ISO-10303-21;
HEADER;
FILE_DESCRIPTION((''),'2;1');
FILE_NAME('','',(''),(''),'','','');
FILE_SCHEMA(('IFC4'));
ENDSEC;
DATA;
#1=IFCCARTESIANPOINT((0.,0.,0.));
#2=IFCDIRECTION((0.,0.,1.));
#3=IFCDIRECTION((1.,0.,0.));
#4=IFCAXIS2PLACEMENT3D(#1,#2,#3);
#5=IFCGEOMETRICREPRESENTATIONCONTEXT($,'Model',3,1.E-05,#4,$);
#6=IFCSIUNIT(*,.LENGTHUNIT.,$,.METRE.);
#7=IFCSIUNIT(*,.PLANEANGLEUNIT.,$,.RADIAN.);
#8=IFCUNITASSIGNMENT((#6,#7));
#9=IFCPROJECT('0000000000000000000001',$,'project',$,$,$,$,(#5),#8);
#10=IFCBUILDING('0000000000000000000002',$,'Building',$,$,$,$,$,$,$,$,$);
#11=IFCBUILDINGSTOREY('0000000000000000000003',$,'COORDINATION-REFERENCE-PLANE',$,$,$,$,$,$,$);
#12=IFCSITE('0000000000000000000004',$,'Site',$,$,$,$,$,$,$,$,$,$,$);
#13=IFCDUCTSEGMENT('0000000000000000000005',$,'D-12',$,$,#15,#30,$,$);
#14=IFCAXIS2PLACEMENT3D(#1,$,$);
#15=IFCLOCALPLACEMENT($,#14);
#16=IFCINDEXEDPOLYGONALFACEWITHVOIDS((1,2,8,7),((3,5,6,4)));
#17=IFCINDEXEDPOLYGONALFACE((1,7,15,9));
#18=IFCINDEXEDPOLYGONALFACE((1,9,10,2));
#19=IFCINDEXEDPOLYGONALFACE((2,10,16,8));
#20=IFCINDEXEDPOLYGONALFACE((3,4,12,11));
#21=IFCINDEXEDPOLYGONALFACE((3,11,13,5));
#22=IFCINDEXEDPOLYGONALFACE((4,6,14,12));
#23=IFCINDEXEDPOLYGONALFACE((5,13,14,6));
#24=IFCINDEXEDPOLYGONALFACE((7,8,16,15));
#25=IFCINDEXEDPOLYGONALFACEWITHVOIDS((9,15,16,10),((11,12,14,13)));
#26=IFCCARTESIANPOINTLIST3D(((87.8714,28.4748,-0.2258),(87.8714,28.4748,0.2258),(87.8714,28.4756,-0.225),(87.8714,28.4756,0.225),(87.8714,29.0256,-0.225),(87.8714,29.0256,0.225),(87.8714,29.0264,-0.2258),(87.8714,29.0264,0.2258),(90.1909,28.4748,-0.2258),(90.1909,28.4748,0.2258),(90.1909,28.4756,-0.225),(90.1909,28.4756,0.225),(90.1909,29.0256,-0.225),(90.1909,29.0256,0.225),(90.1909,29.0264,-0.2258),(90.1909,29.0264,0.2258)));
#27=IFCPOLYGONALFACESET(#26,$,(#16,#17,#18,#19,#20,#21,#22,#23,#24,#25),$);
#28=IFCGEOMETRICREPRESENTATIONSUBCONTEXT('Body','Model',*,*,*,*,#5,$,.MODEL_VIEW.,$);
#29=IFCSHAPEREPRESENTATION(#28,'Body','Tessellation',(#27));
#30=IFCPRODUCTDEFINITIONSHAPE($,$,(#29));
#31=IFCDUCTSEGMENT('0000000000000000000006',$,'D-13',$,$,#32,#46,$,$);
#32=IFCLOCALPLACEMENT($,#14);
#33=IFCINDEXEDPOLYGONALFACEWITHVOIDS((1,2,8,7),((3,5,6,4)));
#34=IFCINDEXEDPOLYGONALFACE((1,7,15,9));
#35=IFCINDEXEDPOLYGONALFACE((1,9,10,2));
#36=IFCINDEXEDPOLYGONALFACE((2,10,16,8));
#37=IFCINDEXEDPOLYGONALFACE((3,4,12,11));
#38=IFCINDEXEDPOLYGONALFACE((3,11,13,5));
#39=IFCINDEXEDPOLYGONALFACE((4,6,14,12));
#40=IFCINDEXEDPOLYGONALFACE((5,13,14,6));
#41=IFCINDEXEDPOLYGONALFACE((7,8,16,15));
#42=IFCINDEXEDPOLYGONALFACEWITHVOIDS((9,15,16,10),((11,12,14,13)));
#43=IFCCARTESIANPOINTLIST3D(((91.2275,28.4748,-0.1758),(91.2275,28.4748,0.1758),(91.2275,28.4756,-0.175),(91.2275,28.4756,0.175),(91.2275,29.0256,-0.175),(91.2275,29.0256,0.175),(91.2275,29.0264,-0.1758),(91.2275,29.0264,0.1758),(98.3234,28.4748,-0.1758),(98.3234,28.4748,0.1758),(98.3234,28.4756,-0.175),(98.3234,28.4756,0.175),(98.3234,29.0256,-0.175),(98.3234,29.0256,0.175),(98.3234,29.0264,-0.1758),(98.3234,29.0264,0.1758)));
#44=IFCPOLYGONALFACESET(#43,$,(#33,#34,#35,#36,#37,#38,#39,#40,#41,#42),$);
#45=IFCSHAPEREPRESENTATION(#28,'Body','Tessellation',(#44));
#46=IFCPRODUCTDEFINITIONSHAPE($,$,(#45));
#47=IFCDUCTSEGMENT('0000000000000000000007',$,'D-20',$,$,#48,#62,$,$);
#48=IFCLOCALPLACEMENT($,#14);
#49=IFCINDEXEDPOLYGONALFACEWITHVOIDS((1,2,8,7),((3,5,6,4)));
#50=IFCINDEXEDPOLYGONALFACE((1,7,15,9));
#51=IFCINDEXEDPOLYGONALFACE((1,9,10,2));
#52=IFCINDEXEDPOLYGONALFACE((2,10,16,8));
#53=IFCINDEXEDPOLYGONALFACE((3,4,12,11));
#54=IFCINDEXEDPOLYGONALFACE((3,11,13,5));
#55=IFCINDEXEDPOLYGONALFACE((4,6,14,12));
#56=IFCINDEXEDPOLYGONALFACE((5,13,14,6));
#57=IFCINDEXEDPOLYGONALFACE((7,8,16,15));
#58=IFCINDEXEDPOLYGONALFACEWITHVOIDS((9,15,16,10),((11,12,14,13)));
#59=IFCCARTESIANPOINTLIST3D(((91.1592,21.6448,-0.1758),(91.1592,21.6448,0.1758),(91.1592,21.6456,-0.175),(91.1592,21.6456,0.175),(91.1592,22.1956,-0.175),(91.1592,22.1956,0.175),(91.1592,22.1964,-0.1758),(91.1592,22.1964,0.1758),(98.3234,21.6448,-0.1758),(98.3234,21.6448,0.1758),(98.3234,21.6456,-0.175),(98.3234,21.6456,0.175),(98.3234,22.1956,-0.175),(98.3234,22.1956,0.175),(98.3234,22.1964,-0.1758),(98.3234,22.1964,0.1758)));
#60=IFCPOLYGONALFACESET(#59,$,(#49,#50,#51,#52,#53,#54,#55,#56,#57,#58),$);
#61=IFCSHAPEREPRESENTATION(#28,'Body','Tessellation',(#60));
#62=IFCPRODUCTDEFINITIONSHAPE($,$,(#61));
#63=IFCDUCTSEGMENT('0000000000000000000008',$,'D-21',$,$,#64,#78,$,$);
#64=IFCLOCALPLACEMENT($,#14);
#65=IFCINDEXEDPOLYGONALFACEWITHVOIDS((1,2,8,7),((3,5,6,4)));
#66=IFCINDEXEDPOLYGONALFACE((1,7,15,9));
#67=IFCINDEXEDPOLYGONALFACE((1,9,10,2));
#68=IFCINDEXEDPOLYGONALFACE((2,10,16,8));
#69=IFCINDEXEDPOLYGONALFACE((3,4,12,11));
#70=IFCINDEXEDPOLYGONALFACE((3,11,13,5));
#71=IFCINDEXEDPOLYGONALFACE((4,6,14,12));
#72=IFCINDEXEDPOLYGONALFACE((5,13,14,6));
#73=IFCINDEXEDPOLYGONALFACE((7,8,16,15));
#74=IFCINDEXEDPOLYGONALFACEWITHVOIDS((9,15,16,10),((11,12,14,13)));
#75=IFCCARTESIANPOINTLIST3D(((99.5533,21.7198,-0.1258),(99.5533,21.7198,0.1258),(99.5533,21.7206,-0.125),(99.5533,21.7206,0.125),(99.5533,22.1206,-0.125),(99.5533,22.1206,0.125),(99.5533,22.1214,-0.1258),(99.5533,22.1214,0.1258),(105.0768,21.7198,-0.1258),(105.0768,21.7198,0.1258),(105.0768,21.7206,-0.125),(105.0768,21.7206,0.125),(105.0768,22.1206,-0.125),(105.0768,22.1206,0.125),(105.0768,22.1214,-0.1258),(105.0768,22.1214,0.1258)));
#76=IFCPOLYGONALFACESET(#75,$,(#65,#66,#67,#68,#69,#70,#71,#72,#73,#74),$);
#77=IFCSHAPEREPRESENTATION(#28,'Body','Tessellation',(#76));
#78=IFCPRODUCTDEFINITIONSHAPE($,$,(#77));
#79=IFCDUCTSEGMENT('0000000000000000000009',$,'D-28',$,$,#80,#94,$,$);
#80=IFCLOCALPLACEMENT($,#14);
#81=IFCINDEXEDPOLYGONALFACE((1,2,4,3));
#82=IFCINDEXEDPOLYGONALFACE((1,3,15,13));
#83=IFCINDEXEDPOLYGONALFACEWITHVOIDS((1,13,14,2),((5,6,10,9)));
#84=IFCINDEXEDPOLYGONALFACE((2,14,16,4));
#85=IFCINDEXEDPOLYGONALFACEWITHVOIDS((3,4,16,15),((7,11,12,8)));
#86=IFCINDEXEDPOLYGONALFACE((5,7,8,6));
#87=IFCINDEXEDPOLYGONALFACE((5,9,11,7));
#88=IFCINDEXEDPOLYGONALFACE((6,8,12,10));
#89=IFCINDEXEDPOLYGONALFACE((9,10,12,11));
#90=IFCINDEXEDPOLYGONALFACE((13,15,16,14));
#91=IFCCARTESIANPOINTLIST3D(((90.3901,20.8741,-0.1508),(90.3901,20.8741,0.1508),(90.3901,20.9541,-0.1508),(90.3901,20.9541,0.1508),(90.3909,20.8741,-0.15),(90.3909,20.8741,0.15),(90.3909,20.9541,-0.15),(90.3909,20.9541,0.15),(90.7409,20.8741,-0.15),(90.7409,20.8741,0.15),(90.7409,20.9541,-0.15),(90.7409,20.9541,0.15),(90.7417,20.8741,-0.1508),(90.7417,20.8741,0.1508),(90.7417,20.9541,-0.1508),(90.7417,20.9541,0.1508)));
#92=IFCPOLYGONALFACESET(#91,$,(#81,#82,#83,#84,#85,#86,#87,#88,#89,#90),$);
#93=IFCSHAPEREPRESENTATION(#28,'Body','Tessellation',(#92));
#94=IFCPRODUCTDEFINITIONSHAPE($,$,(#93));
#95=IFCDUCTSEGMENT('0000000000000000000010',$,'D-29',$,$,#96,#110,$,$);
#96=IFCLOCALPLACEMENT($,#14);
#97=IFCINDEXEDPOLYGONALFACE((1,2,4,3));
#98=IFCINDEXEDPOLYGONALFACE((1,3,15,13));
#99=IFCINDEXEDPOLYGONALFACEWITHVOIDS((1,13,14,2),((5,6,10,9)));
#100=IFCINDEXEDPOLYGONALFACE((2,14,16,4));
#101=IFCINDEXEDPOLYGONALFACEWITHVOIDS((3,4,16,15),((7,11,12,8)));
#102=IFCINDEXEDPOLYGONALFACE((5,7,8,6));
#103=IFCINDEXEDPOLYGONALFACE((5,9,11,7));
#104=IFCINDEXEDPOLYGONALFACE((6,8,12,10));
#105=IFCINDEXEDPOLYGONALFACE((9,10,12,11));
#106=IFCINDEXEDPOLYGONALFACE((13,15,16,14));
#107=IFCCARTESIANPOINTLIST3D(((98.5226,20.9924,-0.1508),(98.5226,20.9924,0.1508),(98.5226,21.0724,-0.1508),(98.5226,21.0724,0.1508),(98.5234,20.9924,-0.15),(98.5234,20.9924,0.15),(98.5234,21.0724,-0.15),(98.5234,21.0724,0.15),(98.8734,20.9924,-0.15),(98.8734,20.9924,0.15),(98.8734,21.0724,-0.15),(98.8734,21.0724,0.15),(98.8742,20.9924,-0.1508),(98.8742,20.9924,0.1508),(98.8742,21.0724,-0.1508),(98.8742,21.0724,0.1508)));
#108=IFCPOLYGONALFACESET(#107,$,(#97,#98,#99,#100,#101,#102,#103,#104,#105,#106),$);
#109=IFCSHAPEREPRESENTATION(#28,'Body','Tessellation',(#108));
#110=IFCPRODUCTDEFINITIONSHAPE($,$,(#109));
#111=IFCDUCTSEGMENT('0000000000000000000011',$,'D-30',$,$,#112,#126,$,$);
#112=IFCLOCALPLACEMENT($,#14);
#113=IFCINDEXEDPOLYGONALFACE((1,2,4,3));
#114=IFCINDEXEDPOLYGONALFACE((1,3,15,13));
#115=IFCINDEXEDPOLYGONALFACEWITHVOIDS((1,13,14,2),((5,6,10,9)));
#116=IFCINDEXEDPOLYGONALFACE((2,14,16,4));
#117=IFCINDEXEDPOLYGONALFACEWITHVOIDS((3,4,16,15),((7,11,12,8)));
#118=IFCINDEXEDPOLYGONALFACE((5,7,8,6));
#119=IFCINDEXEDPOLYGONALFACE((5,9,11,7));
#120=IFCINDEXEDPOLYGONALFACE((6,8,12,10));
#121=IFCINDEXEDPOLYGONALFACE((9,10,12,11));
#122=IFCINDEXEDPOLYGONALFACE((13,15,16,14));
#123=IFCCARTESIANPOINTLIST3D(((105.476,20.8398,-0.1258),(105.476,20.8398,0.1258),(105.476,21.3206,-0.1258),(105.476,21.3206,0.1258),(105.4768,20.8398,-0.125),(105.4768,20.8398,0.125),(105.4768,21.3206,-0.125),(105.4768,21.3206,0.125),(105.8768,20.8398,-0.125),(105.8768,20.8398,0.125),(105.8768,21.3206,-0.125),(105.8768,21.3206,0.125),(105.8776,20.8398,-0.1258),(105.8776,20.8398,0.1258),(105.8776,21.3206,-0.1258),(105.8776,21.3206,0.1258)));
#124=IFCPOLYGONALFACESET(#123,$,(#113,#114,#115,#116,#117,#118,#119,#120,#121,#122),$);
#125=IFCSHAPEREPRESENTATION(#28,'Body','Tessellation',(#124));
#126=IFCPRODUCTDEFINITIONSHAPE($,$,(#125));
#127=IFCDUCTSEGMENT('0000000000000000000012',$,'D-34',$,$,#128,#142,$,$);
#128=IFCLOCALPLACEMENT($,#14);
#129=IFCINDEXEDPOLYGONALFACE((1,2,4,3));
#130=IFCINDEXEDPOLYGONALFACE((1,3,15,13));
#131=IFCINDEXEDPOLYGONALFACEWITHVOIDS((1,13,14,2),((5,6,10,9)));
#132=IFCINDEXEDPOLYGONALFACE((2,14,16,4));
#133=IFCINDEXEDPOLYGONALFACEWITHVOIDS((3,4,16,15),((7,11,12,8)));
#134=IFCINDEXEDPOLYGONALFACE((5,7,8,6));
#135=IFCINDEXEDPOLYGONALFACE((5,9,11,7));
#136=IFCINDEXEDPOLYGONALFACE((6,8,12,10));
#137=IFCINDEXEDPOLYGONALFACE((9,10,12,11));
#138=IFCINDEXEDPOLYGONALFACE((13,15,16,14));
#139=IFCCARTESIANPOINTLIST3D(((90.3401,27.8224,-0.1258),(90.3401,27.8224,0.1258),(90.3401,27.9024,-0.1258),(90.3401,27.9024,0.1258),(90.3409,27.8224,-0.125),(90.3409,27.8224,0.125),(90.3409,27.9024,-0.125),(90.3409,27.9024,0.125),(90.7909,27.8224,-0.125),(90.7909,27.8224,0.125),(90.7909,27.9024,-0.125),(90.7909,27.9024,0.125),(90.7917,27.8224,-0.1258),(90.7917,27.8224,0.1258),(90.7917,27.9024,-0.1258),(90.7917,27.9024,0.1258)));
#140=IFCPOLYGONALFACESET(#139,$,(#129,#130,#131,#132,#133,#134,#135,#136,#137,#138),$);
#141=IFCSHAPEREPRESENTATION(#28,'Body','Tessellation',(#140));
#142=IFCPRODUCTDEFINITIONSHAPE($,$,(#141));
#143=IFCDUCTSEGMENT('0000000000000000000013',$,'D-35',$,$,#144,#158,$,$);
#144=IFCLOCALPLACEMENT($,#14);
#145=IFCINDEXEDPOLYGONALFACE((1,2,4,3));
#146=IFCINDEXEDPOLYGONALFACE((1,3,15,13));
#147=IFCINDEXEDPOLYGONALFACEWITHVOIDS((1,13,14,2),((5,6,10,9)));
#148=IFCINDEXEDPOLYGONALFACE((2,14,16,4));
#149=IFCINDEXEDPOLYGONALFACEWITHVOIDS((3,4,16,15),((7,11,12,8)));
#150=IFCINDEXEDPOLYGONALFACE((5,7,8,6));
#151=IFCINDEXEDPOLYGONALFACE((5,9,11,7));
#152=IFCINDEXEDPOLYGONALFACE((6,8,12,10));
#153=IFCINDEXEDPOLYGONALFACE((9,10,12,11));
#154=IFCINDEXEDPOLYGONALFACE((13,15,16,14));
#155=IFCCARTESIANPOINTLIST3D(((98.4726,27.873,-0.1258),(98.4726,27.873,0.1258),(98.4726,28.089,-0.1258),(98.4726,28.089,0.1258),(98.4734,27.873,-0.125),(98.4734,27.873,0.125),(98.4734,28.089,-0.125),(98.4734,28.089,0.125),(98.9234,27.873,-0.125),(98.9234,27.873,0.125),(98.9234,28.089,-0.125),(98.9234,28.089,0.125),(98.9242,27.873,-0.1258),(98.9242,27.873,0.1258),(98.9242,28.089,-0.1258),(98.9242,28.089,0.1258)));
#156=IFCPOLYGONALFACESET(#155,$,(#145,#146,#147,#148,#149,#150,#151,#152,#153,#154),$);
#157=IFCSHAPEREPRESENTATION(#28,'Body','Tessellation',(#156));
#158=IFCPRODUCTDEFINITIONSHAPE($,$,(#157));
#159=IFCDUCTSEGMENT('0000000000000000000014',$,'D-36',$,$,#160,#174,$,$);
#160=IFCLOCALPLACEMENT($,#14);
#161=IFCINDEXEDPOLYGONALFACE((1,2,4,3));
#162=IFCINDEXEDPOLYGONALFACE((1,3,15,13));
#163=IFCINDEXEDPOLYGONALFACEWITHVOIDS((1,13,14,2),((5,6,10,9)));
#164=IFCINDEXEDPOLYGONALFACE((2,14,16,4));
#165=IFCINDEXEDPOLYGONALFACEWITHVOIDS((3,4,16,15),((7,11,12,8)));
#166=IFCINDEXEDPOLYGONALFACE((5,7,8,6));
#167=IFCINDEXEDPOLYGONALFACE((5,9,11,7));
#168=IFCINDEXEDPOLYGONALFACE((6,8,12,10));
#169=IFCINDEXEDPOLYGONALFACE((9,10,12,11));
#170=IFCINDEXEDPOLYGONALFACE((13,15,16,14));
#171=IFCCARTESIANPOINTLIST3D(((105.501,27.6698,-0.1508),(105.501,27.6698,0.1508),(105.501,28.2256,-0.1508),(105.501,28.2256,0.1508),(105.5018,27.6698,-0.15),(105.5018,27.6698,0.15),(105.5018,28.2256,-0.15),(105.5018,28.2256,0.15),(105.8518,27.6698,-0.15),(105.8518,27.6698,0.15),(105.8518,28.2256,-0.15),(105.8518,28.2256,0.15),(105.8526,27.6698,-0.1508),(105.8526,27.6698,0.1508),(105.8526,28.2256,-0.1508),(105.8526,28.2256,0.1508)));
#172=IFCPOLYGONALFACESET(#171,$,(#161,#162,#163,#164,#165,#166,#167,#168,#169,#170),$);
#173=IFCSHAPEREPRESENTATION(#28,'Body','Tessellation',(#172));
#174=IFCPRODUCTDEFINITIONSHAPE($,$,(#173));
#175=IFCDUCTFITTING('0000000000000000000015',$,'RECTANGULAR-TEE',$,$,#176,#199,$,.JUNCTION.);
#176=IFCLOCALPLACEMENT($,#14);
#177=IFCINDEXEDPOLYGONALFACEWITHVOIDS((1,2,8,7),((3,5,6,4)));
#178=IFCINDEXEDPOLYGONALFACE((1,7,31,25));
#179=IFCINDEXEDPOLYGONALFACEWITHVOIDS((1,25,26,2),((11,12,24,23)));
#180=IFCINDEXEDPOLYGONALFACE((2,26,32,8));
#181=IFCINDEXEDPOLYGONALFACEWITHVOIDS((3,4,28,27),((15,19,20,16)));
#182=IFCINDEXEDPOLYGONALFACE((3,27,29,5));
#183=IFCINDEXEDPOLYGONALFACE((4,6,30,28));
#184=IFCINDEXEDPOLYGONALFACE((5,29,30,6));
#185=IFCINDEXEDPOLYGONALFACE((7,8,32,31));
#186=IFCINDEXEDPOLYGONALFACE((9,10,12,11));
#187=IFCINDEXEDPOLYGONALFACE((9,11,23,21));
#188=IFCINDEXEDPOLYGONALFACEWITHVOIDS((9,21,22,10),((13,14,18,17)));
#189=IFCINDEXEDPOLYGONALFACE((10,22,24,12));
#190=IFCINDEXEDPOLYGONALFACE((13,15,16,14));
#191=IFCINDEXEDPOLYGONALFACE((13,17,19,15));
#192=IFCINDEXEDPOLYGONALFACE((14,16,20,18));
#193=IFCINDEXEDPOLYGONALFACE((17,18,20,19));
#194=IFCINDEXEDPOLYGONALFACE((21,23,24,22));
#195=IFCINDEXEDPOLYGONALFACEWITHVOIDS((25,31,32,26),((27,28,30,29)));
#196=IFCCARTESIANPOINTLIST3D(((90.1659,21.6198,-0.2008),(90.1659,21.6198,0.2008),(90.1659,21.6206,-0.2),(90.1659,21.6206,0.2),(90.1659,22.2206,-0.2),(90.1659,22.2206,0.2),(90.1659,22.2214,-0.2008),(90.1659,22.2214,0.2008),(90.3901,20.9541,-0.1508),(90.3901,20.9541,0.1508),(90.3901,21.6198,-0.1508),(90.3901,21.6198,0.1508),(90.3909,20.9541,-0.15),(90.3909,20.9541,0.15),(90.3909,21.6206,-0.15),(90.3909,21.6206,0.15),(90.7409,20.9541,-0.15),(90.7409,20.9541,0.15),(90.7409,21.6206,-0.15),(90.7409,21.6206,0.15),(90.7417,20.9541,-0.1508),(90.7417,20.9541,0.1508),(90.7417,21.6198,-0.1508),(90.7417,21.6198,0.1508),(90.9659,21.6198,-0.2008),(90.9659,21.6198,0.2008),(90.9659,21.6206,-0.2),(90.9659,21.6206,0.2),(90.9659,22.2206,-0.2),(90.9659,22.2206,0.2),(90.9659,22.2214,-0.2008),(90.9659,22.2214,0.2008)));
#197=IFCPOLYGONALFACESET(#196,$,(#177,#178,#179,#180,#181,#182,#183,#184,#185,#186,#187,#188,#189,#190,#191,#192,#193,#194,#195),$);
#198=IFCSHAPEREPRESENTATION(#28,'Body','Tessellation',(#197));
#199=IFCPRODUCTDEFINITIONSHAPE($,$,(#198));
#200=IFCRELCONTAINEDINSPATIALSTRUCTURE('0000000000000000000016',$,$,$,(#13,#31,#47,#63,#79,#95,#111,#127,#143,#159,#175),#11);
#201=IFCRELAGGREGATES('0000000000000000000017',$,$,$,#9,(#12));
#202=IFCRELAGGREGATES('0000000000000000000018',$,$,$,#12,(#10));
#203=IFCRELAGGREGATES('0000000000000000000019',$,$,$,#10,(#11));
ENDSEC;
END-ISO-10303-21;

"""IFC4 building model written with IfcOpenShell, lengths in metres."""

from ifc_helpers import new_model, si_unit, frame, origin, origin_with_axes, place, context, subcontext, project, spatial, rectangle, hollow_rectangle, extrude, boolean, element, save


model = new_model("IFC4")

# Units and contexts
model_context = context("Model", 3, precision=1e-05, world=origin_with_axes())
body_context_1 = subcontext(model_context, "Body", "Model", "MODEL_VIEW")
ifc_project = project(units=[si_unit("LENGTHUNIT", "METRE"), si_unit("PLANEANGLEUNIT", "RADIAN")], contexts=[model_context])

# Site, building, storey
site = spatial("IfcSite", under=ifc_project, Name="Site")
building = spatial("IfcBuilding", under=site, Name="Building")
storey = spatial("IfcBuildingStorey", under=building, Name="COORDINATION-REFERENCE-PLANE")

# Duct segments
duct_segment_1_placement = place(None, frame((87.8714, 28.7506, 0.0), z_axis=(1.0, 0.0, 0.0), x_axis=(0.0, 1.0, 0.0)))
element("IfcDuctSegment", 1, at=duct_segment_1_placement, inside=storey, Name="D-12", context=body_context_1, shape_type="SweptSolid", body=[
    extrude(hollow_rectangle(XDim=0.5516, YDim=0.4516, WallThickness=0.0008), origin(), (0.0, 0.0, 1.0), 2.3195),
])
duct_segment_2_placement = place(None, frame((91.2275, 28.7506, 0.0), z_axis=(1.0, 0.0, 0.0), x_axis=(0.0, 1.0, 0.0)))
element("IfcDuctSegment", 2, at=duct_segment_2_placement, inside=storey, Name="D-13", context=body_context_1, shape_type="SweptSolid", body=[
    extrude(hollow_rectangle(XDim=0.5516, YDim=0.3516, WallThickness=0.0008), origin(), (0.0, 0.0, 1.0), 7.0959),
])
duct_segment_3_placement = place(None, frame((91.1592, 21.9206, 0.0), z_axis=(1.0, 0.0, 0.0), x_axis=(0.0, 1.0, 0.0)))
element("IfcDuctSegment", 3, at=duct_segment_3_placement, inside=storey, Name="D-20", context=body_context_1, shape_type="SweptSolid", body=[
    extrude(hollow_rectangle(XDim=0.5516, YDim=0.3516, WallThickness=0.0008), origin(), (0.0, 0.0, 1.0), 7.1642),
])
duct_segment_4_placement = place(None, frame((99.5533, 21.9206, 0.0), z_axis=(1.0, 0.0, 0.0), x_axis=(0.0, 1.0, 0.0)))
element("IfcDuctSegment", 4, at=duct_segment_4_placement, inside=storey, Name="D-21", context=body_context_1, shape_type="SweptSolid", body=[
    extrude(hollow_rectangle(XDim=0.4016, YDim=0.2516, WallThickness=0.0008), origin(), (0.0, 0.0, 1.0), 5.5234),
])
for number, where, z_axis, x_axis, name in (
    (5, (90.5659, 20.8741, 0.0), (0.0, 1.0, 0.0), (1.0, 0.0, 0.0), "D-28"),
    (6, (98.6984, 20.9924, 0.0), (0.0, 1.0, 0.0), (1.0, 0.0, 0.0), "D-29"),
):
    element("IfcDuctSegment", number, at=place(None, frame(where, z_axis=z_axis, x_axis=x_axis)), inside=storey, Name=name, context=body_context_1, shape_type="SweptSolid", body=[
        extrude(hollow_rectangle(XDim=0.3516, YDim=0.3016, WallThickness=0.0008), origin(), (0.0, 0.0, 1.0), 0.08),
    ])
duct_segment_5_placement = place(None, frame((105.6768, 20.8398, 0.0), z_axis=(0.0, 1.0, 0.0), x_axis=(1.0, 0.0, 0.0)))
element("IfcDuctSegment", 7, at=duct_segment_5_placement, inside=storey, Name="D-30", context=body_context_1, shape_type="SweptSolid", body=[
    extrude(hollow_rectangle(XDim=0.4016, YDim=0.2516, WallThickness=0.0008), origin(), (0.0, 0.0, 1.0), 0.4808),
])
duct_segment_6_placement = place(None, frame((90.5659, 27.8224, 0.0), z_axis=(0.0, 1.0, 0.0), x_axis=(1.0, 0.0, 0.0)))
element("IfcDuctSegment", 8, at=duct_segment_6_placement, inside=storey, Name="D-34", context=body_context_1, shape_type="SweptSolid", body=[
    extrude(hollow_rectangle(XDim=0.4516, YDim=0.2516, WallThickness=0.0008), origin(), (0.0, 0.0, 1.0), 0.08),
])
duct_segment_7_placement = place(None, frame((98.6984, 27.873, 0.0), z_axis=(0.0, 1.0, 0.0), x_axis=(1.0, 0.0, 0.0)))
element("IfcDuctSegment", 9, at=duct_segment_7_placement, inside=storey, Name="D-35", context=body_context_1, shape_type="SweptSolid", body=[
    extrude(hollow_rectangle(XDim=0.4516, YDim=0.2516, WallThickness=0.0008), origin(), (0.0, 0.0, 1.0), 0.216),
])
duct_segment_8_placement = place(None, frame((105.6768, 27.6698, 0.0), z_axis=(0.0, 1.0, 0.0), x_axis=(1.0, 0.0, 0.0)))
element("IfcDuctSegment", 10, at=duct_segment_8_placement, inside=storey, Name="D-36", context=body_context_1, shape_type="SweptSolid", body=[
    extrude(hollow_rectangle(XDim=0.3516, YDim=0.3016, WallThickness=0.0008), origin(), (0.0, 0.0, 1.0), 0.5558),
])

# Duct fitting
duct_fitting_1_placement = place(None, frame((90.5659, 21.9206, 0.0), z_axis=(1.0, 0.0, 0.0), x_axis=(0.0, -1.0, 0.0)))
solid_1 = boolean("UNION", extrude(rectangle(XDim=0.6, YDim=0.4), frame((0.0, 0.0, -0.4), z_axis=(0.0, 0.0, 1.0), x_axis=(1.0, 0.0, 0.0)), (0.0, 0.0, 1.0), 0.8), extrude(rectangle(XDim=0.35, YDim=0.3), frame((0.0, 0.0, 0.0), z_axis=(1.0, 0.0, 0.0), x_axis=(0.0, 0.0, -1.0)), (0.0, 0.0, 1.0), 0.9665))
element("IfcDuctFitting", 11, at=duct_fitting_1_placement, inside=storey, Name="RECTANGULAR-TEE", PredefinedType="JUNCTION", context=body_context_1, shape_type="CSG", body=[
    boolean("DIFFERENCE", boolean("UNION", extrude(rectangle(XDim=0.6016, YDim=0.4016), frame((0.0, 0.0, -0.4), z_axis=(0.0, 0.0, 1.0), x_axis=(1.0, 0.0, 0.0)), (0.0, 0.0, 1.0), 0.8), extrude(rectangle(XDim=0.3516, YDim=0.3016), frame((0.0, 0.0, 0.0), z_axis=(1.0, 0.0, 0.0), x_axis=(0.0, 0.0, -1.0)), (0.0, 0.0, 1.0), 0.9665)), solid_1),
])

save(model, "model.ifc")
